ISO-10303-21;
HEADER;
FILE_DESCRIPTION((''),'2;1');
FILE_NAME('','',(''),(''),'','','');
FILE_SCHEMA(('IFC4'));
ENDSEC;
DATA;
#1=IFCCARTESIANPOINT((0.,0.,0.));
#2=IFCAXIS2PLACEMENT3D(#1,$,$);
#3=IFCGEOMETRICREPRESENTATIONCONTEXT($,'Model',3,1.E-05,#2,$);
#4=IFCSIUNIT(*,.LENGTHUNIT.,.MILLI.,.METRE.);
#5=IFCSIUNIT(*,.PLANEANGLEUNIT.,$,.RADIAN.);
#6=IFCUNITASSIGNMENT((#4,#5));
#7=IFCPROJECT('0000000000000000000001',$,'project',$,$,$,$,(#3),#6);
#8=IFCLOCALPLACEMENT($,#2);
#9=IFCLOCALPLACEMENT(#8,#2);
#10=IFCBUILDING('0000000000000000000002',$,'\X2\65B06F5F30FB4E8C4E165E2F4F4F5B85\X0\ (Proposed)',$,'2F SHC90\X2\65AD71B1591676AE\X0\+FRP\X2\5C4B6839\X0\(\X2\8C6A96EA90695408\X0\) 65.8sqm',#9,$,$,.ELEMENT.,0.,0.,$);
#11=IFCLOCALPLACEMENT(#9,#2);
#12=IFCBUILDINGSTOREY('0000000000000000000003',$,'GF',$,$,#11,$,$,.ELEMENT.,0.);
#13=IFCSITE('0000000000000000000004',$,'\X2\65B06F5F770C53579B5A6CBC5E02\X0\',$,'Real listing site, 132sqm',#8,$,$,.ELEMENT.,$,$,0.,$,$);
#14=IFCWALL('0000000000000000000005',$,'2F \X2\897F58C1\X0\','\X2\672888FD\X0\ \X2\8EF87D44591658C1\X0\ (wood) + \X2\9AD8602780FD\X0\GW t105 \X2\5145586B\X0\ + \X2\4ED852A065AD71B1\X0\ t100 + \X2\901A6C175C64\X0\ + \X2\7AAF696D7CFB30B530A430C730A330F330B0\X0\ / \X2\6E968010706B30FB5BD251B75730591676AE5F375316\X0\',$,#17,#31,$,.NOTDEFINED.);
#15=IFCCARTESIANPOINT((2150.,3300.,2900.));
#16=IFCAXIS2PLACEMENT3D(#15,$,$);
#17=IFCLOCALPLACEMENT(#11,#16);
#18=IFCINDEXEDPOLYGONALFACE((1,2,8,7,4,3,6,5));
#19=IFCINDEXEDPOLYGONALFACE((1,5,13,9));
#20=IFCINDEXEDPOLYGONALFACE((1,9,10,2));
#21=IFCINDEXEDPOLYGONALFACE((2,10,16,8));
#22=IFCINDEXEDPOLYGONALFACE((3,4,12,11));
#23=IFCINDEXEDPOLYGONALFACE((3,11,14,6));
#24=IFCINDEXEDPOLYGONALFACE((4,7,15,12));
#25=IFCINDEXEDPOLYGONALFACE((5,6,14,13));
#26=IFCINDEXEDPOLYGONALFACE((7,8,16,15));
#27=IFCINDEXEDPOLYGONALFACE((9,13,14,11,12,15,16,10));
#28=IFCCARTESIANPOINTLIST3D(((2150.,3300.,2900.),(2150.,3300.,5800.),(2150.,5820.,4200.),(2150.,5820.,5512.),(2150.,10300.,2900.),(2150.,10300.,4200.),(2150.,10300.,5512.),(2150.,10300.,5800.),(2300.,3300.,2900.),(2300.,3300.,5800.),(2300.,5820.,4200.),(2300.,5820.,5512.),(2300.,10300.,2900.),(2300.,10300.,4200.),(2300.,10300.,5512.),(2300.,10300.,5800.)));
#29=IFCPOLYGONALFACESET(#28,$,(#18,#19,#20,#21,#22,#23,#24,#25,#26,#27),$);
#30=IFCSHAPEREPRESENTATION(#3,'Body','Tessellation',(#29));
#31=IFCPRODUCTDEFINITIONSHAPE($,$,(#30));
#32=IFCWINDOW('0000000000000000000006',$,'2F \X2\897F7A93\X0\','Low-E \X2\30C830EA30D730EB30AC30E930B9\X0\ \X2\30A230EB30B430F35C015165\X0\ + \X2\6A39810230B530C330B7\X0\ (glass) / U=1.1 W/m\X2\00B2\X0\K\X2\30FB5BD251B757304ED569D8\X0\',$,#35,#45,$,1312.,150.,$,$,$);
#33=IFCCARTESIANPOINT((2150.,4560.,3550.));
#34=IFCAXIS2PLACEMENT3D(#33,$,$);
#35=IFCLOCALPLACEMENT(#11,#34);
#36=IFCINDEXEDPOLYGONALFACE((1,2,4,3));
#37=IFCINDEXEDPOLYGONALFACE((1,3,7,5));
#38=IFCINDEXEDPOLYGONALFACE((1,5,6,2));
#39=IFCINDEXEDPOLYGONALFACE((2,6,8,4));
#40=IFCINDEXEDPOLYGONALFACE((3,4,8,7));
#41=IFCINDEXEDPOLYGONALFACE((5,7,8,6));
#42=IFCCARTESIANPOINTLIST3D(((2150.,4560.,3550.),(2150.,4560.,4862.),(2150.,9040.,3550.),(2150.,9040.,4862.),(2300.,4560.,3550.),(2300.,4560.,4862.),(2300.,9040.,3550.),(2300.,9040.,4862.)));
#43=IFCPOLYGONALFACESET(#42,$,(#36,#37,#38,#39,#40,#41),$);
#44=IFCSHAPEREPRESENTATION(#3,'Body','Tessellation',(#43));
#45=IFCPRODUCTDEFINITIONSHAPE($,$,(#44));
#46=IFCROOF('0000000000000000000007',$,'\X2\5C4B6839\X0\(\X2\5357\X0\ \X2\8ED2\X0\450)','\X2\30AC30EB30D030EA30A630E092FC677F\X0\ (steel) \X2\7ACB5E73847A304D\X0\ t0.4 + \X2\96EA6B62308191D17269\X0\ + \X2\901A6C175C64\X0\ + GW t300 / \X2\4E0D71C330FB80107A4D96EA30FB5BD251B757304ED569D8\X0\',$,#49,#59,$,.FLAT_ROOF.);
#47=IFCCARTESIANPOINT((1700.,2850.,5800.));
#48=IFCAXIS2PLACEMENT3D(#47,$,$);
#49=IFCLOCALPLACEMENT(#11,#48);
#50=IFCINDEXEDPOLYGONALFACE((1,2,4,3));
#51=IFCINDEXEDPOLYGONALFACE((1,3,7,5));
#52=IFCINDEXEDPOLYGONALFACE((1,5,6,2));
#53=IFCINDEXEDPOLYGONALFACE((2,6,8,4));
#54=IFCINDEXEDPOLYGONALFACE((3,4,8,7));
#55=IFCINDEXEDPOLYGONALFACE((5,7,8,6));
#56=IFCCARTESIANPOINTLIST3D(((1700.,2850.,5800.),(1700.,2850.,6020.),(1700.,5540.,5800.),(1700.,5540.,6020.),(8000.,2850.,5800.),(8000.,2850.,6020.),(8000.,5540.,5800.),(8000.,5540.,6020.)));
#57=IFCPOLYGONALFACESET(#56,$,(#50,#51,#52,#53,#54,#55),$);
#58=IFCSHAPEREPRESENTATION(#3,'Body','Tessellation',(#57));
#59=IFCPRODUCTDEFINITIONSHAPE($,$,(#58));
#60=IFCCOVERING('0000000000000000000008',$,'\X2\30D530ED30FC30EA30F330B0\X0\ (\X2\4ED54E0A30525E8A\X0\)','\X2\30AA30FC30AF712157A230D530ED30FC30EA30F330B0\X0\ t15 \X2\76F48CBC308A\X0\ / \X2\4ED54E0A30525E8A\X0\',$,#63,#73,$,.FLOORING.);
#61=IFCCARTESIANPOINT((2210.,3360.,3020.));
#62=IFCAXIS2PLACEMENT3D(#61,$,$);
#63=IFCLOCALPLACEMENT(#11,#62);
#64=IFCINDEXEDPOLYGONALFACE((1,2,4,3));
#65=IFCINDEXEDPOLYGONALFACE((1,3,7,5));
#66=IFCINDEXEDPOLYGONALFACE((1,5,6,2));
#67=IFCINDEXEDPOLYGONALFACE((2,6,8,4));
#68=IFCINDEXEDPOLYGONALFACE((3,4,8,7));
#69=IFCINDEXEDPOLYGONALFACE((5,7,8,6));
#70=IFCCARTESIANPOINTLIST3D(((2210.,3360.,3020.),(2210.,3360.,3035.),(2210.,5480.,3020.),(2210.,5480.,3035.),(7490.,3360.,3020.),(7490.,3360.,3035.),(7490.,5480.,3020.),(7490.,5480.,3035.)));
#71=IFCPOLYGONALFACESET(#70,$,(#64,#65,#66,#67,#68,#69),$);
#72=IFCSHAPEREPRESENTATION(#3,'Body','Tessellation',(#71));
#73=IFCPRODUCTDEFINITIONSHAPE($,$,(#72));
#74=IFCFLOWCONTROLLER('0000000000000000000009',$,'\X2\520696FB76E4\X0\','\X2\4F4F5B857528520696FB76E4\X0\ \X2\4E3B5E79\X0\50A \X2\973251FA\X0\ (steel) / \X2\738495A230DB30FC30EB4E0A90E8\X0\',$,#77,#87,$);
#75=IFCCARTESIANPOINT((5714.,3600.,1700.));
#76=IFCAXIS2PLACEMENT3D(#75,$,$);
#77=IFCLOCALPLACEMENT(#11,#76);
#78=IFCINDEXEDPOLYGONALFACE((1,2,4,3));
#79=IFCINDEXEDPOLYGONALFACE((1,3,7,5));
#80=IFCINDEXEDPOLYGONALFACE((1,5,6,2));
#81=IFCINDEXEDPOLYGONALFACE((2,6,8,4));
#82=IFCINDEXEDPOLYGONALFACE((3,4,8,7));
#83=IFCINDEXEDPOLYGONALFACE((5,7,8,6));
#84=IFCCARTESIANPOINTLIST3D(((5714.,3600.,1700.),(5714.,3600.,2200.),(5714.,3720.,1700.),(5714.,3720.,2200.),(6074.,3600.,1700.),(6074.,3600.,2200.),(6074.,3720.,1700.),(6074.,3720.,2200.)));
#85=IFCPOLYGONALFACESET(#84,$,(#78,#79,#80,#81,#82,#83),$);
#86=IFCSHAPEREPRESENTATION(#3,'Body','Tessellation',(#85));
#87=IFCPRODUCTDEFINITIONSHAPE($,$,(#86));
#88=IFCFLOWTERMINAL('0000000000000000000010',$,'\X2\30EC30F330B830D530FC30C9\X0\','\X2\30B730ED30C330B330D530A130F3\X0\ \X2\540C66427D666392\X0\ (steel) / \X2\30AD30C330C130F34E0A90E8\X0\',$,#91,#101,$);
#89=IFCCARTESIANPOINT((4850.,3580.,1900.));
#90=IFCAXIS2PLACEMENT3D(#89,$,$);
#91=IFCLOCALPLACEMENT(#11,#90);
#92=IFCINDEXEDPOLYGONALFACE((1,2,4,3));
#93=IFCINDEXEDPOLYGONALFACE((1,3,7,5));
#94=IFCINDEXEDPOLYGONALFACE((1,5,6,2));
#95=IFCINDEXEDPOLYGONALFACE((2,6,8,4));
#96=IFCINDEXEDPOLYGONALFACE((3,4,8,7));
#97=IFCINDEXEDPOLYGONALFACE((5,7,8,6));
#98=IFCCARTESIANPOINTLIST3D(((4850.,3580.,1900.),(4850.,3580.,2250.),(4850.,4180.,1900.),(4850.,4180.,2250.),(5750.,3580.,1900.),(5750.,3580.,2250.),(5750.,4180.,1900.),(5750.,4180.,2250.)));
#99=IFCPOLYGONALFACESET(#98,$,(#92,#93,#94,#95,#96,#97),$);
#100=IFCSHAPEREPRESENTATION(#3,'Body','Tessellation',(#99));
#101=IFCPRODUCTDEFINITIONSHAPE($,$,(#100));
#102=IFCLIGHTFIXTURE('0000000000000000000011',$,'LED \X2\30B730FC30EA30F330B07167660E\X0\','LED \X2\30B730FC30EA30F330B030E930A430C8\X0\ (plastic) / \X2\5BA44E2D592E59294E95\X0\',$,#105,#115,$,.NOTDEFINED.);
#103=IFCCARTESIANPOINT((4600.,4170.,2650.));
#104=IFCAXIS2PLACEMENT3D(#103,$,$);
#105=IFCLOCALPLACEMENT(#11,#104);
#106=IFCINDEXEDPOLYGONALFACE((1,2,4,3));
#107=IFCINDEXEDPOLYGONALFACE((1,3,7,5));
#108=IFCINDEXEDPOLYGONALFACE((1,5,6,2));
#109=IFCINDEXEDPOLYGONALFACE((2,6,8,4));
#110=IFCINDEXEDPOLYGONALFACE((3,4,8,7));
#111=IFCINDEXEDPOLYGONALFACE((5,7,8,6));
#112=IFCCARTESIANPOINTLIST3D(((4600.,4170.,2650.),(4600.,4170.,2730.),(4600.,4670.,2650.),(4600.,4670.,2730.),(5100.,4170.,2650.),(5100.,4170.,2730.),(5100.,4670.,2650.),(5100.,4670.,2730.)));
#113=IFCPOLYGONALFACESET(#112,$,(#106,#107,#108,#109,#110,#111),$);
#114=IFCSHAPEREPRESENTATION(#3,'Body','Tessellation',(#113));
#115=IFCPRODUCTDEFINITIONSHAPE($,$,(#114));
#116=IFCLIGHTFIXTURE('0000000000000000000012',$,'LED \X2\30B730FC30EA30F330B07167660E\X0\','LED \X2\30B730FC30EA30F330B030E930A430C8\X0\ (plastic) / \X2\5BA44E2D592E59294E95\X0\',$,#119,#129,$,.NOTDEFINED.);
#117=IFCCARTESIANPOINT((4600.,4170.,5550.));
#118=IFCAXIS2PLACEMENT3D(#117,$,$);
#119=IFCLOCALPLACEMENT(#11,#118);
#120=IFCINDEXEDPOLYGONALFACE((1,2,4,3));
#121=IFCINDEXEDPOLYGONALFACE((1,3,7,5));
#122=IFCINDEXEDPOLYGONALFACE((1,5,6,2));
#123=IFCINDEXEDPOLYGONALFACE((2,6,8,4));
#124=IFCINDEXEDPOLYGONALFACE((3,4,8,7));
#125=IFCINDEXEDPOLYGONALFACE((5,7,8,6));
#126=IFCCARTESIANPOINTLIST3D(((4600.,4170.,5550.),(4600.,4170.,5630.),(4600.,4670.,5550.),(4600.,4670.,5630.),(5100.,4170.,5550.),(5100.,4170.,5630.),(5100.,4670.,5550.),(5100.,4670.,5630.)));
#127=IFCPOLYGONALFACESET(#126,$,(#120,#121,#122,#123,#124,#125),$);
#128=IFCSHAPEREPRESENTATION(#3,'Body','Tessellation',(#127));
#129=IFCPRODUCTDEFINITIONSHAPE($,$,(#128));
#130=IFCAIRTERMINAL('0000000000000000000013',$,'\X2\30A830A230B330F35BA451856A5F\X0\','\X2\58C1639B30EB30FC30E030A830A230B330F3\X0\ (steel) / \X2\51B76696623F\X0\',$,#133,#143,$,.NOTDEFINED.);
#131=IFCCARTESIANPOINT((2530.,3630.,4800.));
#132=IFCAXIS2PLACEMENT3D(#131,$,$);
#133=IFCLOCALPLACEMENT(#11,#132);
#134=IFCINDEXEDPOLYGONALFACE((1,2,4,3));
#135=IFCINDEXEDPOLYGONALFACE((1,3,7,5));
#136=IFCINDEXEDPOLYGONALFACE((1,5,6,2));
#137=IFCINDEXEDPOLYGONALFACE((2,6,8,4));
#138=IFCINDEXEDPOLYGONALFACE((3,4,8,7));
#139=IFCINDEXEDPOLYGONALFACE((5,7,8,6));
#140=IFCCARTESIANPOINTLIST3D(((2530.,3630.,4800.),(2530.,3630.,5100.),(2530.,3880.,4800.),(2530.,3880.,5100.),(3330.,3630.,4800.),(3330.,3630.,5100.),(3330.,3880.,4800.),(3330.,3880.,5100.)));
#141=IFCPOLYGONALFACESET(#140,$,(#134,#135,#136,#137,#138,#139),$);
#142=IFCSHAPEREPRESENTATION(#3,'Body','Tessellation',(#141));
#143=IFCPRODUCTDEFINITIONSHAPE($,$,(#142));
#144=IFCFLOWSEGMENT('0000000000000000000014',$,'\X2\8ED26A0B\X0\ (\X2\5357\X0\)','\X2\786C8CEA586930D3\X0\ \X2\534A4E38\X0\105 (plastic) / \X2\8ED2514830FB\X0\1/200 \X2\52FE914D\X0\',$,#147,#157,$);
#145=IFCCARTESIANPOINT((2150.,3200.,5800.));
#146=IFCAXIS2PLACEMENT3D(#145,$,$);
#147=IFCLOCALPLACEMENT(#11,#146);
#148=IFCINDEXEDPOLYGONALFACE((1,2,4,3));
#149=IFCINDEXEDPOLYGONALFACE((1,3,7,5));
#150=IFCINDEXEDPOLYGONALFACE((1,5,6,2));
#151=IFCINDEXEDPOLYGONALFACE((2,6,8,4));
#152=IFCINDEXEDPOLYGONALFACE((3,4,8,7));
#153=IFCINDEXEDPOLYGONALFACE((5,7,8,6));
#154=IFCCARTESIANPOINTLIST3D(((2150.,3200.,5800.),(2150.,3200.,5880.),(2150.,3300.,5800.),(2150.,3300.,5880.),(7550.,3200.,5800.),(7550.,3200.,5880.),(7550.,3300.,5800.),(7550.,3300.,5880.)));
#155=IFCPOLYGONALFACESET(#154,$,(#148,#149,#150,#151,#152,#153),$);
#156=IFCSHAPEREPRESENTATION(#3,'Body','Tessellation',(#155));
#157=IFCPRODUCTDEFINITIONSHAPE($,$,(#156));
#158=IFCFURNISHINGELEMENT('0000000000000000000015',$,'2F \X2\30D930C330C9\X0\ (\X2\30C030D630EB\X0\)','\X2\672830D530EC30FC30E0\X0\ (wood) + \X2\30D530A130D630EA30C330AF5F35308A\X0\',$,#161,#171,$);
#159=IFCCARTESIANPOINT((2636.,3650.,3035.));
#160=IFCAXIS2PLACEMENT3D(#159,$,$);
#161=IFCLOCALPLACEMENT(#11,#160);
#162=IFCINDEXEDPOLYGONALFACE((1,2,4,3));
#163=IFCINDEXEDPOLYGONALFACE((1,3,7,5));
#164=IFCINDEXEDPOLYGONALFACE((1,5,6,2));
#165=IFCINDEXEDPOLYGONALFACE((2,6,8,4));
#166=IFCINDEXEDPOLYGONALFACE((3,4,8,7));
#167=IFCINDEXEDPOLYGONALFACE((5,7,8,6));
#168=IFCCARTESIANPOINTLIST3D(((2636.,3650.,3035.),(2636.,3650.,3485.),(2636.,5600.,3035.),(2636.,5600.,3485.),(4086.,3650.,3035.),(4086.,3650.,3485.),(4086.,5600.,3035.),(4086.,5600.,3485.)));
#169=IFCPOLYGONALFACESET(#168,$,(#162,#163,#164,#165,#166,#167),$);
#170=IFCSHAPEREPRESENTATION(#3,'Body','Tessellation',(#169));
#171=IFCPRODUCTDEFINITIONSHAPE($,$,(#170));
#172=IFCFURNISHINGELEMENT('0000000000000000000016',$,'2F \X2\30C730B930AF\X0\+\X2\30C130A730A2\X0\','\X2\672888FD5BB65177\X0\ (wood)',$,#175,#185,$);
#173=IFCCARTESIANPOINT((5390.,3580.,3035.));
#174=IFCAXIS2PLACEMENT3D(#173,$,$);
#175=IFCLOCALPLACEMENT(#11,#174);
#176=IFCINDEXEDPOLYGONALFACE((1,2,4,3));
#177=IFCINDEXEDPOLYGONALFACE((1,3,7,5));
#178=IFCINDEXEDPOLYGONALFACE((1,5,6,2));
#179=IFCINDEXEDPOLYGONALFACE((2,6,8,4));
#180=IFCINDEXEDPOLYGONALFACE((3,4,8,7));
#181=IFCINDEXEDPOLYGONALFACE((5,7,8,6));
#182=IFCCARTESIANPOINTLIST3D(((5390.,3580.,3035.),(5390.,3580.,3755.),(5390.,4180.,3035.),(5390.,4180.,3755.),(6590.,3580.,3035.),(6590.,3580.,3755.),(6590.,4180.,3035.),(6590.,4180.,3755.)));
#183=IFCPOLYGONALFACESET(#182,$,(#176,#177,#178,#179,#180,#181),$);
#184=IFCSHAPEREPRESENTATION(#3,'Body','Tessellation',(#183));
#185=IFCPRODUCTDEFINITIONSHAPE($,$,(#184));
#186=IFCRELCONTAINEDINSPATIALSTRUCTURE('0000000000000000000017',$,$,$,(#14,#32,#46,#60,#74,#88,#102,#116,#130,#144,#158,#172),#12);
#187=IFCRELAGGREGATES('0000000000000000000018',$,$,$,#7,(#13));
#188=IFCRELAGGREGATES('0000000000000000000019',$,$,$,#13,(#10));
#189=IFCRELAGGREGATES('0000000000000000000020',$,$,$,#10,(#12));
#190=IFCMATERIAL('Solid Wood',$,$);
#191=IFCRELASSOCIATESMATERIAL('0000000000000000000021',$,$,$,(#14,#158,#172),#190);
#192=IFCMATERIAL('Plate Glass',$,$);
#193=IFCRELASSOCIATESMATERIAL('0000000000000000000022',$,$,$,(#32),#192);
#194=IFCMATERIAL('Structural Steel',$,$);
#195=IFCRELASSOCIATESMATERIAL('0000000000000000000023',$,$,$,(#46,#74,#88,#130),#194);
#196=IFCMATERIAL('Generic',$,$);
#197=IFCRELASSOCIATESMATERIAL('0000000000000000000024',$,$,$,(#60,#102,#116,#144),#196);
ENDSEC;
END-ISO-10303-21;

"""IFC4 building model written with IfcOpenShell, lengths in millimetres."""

from ifc_helpers import new_model, si_unit, frame, frame_2d, origin, place, context, project, spatial, rectangle, extrude, material, element, fill, save


model = new_model("IFC4")

# Units and contexts
model_context = context("Model", 3, precision=1e-05, world=origin())
ifc_project = project(units=[si_unit("LENGTHUNIT", "METRE", prefix="MILLI"), si_unit("PLANEANGLEUNIT", "RADIAN")], contexts=[model_context])

# Site, building, storey
site_placement = place(None, origin())
site = spatial("IfcSite", under=ifc_project, at=site_placement, Name="新潟県南魚沼市", ObjectType="Real listing site, 132sqm", CompositionType="ELEMENT", RefElevation=0.0)
building_placement = place(site_placement, origin())
building = spatial("IfcBuilding", under=site, at=building_placement, Name="新潟・二世帯住宅 (Proposed)", ObjectType="2F SHC90断熱外皮+FRP屋根(豪雪適合) 65.8sqm", CompositionType="ELEMENT", ElevationOfRefHeight=0.0, ElevationOfTerrain=0.0)
storey_placement = place(building_placement, origin())
storey = spatial("IfcBuildingStorey", under=building, at=storey_placement, Name="GF", CompositionType="ELEMENT", Elevation=0.0)

# Shared definitions
ifc_material_1 = material(Name="Solid Wood")

# Wall, opening, window
ifc_material_2 = material(Name="Plate Glass")
wall_1_placement = place(storey_placement, frame((2150.0, 3300.0, 2900.0)))
wall_1 = element("IfcWall", 1, at=wall_1_placement, inside=storey, material=ifc_material_1, Name="2F 西壁", Description="木製 軸組外壁 (wood) + 高性能GW t105 充填 + 付加断熱 t100 + 通気層 + 窯業系サイディング / 準耐火・寒冷地外皮強化", PredefinedType="NOTDEFINED", context=model_context, shape_type="SweptSolid", body=[
    extrude(rectangle(XDim=150.0, YDim=7000.0, at=frame_2d((75.0, 3500.0))), frame((2150.0, 3300.0, 2900.0)), (0.0, 0.0, 1.0), 2900.0),
])
opening_1_placement = place(storey_placement, frame((2150.0, 4560.0, 3550.0)))
opening_1 = element("IfcOpeningElement", 2, at=opening_1_placement, cuts=wall_1, PredefinedType="NOTDEFINED", context=model_context, shape_type="SweptSolid", body=[
    extrude(rectangle(XDim=150.0, YDim=4480.0, at=frame_2d((75.0, 2240.0))), frame((2150.0, 4560.0, 3550.0)), (0.0, 0.0, 1.0), 1312.0),
])
window_1_placement = place(storey_placement, frame((2150.0, 4560.0, 3550.0)))
window_1 = element("IfcWindow", 3, at=window_1_placement, inside=storey, material=ifc_material_2, Name="2F 西窓", Description="Low-E トリプルガラス アルゴン封入 + 樹脂サッシ (glass) / U=1.1 W/m²K・寒冷地仕様", OverallHeight=1312.0, OverallWidth=150.0, context=model_context, shape_type="SweptSolid", body=[
    extrude(rectangle(XDim=150.0, YDim=4480.0, at=frame_2d((75.0, 2240.0))), frame((2150.0, 4560.0, 3550.0)), (0.0, 0.0, 1.0), 1312.0),
])
fill(opening_1, window_1)

# Roof
ifc_material_3 = material(Name="Structural Steel")
for number, where, name in (
    (4, (1700.0, 2850.0, 5800.0), "屋根(南 軒450)"),
):
    element("IfcRoof", number, at=place(storey_placement, frame(where)), inside=storey, material=ifc_material_3, Name=name, Description="ガルバリウム鋼板 (steel) 立平葺き t0.4 + 雪止め金物 + 通気層 + GW t300 / 不燃・耐積雪・寒冷地仕様", PredefinedType="FLAT_ROOF", context=model_context, shape_type="SweptSolid", body=[
        extrude(rectangle(XDim=6300.0, YDim=2690.0, at=frame_2d((3150.0, 1345.0))), frame((1700.0, 2850.0, 5800.0)), (0.0, 0.0, 1.0), 220.0),
    ])

# Covering
ifc_material_4 = material(Name="Generic")
covering_placement = place(storey_placement, frame((2210.0, 3360.0, 3020.0)))
element("IfcCovering", 5, at=covering_placement, inside=storey, material=ifc_material_4, Name="フローリング (仕上げ床)", Description="オーク無垢フローリング t15 直貼り / 仕上げ床", PredefinedType="FLOORING", context=model_context, shape_type="SweptSolid", body=[
    extrude(rectangle(XDim=5280.0, YDim=2120.0, at=frame_2d((2640.0, 1060.0))), frame((2210.0, 3360.0, 3020.0)), (0.0, 0.0, 1.0), 15.0),
])

# Flow controller
flow_controller_placement = place(storey_placement, frame((5714.0, 3600.0, 1700.0)))
element("IfcFlowController", 6, at=flow_controller_placement, inside=storey, material=ifc_material_3, Name="分電盤", Description="住宅用分電盤 主幹50A 露出 (steel) / 玄関ホール上部", context=model_context, shape_type="SweptSolid", body=[
    extrude(rectangle(XDim=360.0, YDim=120.0, at=frame_2d((180.0, 60.0))), frame((5714.0, 3600.0, 1700.0)), (0.0, 0.0, 1.0), 500.0),
])

# Flow terminal
flow_terminal_placement = place(storey_placement, frame((4850.0, 3580.0, 1900.0)))
element("IfcFlowTerminal", 7, at=flow_terminal_placement, inside=storey, material=ifc_material_3, Name="レンジフード", Description="シロッコファン 同時給排 (steel) / キッチン上部", context=model_context, shape_type="SweptSolid", body=[
    extrude(rectangle(XDim=900.0, YDim=600.0, at=frame_2d((450.0, 300.0))), frame((4850.0, 3580.0, 1900.0)), (0.0, 0.0, 1.0), 350.0),
])

# Light fixtures
light_fixture_1_placement = place(storey_placement, frame((4600.0, 4170.0, 2650.0)))
element("IfcLightFixture", 8, at=light_fixture_1_placement, inside=storey, material=ifc_material_4, Name="LED シーリング照明", Description="LED シーリングライト (plastic) / 室中央天井", PredefinedType="NOTDEFINED", context=model_context, shape_type="SweptSolid", body=[
    extrude(rectangle(XDim=500.0, YDim=500.0, at=frame_2d((250.0, 250.0))), frame((4600.0, 4170.0, 2650.0)), (0.0, 0.0, 1.0), 80.0),
])
light_fixture_2_placement = place(storey_placement, frame((4600.0, 4170.0, 5550.0)))
element("IfcLightFixture", 9, at=light_fixture_2_placement, inside=storey, material=ifc_material_4, Name="LED シーリング照明", Description="LED シーリングライト (plastic) / 室中央天井", PredefinedType="NOTDEFINED", context=model_context, shape_type="SweptSolid", body=[
    extrude(rectangle(XDim=500.0, YDim=500.0, at=frame_2d((250.0, 250.0))), frame((4600.0, 4170.0, 5550.0)), (0.0, 0.0, 1.0), 80.0),
])

# Air terminal
air_terminal_placement = place(storey_placement, frame((2530.0, 3630.0, 4800.0)))
element("IfcAirTerminal", 10, at=air_terminal_placement, inside=storey, material=ifc_material_3, Name="エアコン室内機", Description="壁掛ルームエアコン (steel) / 冷暖房", PredefinedType="NOTDEFINED", context=model_context, shape_type="SweptSolid", body=[
    extrude(rectangle(XDim=800.0, YDim=250.0, at=frame_2d((400.0, 125.0))), frame((2530.0, 3630.0, 4800.0)), (0.0, 0.0, 1.0), 300.0),
])

# Flow segment
flow_segment_placement = place(storey_placement, frame((2150.0, 3200.0, 5800.0)))
element("IfcFlowSegment", 11, at=flow_segment_placement, inside=storey, material=ifc_material_4, Name="軒樋 (南)", Description="硬質塩ビ 半丸105 (plastic) / 軒先・1/200 勾配", context=model_context, shape_type="SweptSolid", body=[
    extrude(rectangle(XDim=5400.0, YDim=100.0, at=frame_2d((2700.0, 50.0))), frame((2150.0, 3200.0, 5800.0)), (0.0, 0.0, 1.0), 80.0),
])

# Furnishing elements
furnishing_1_placement = place(storey_placement, frame((2636.0, 3650.0, 3035.0)))
element("IfcFurnishingElement", 12, at=furnishing_1_placement, inside=storey, material=ifc_material_1, Name="2F ベッド (ダブル)", Description="木フレーム (wood) + ファブリック張り", context=model_context, shape_type="SweptSolid", body=[
    extrude(rectangle(XDim=1450.0, YDim=1950.0, at=frame_2d((725.0, 975.0))), frame((2636.0, 3650.0, 3035.0)), (0.0, 0.0, 1.0), 450.0),
])
furnishing_2_placement = place(storey_placement, frame((5390.0, 3580.0, 3035.0)))
element("IfcFurnishingElement", 13, at=furnishing_2_placement, inside=storey, material=ifc_material_1, Name="2F デスク+チェア", Description="木製家具 (wood)", context=model_context, shape_type="SweptSolid", body=[
    extrude(rectangle(XDim=1200.0, YDim=600.0, at=frame_2d((600.0, 300.0))), frame((5390.0, 3580.0, 3035.0)), (0.0, 0.0, 1.0), 720.0),
])

save(model, "model.ifc")
